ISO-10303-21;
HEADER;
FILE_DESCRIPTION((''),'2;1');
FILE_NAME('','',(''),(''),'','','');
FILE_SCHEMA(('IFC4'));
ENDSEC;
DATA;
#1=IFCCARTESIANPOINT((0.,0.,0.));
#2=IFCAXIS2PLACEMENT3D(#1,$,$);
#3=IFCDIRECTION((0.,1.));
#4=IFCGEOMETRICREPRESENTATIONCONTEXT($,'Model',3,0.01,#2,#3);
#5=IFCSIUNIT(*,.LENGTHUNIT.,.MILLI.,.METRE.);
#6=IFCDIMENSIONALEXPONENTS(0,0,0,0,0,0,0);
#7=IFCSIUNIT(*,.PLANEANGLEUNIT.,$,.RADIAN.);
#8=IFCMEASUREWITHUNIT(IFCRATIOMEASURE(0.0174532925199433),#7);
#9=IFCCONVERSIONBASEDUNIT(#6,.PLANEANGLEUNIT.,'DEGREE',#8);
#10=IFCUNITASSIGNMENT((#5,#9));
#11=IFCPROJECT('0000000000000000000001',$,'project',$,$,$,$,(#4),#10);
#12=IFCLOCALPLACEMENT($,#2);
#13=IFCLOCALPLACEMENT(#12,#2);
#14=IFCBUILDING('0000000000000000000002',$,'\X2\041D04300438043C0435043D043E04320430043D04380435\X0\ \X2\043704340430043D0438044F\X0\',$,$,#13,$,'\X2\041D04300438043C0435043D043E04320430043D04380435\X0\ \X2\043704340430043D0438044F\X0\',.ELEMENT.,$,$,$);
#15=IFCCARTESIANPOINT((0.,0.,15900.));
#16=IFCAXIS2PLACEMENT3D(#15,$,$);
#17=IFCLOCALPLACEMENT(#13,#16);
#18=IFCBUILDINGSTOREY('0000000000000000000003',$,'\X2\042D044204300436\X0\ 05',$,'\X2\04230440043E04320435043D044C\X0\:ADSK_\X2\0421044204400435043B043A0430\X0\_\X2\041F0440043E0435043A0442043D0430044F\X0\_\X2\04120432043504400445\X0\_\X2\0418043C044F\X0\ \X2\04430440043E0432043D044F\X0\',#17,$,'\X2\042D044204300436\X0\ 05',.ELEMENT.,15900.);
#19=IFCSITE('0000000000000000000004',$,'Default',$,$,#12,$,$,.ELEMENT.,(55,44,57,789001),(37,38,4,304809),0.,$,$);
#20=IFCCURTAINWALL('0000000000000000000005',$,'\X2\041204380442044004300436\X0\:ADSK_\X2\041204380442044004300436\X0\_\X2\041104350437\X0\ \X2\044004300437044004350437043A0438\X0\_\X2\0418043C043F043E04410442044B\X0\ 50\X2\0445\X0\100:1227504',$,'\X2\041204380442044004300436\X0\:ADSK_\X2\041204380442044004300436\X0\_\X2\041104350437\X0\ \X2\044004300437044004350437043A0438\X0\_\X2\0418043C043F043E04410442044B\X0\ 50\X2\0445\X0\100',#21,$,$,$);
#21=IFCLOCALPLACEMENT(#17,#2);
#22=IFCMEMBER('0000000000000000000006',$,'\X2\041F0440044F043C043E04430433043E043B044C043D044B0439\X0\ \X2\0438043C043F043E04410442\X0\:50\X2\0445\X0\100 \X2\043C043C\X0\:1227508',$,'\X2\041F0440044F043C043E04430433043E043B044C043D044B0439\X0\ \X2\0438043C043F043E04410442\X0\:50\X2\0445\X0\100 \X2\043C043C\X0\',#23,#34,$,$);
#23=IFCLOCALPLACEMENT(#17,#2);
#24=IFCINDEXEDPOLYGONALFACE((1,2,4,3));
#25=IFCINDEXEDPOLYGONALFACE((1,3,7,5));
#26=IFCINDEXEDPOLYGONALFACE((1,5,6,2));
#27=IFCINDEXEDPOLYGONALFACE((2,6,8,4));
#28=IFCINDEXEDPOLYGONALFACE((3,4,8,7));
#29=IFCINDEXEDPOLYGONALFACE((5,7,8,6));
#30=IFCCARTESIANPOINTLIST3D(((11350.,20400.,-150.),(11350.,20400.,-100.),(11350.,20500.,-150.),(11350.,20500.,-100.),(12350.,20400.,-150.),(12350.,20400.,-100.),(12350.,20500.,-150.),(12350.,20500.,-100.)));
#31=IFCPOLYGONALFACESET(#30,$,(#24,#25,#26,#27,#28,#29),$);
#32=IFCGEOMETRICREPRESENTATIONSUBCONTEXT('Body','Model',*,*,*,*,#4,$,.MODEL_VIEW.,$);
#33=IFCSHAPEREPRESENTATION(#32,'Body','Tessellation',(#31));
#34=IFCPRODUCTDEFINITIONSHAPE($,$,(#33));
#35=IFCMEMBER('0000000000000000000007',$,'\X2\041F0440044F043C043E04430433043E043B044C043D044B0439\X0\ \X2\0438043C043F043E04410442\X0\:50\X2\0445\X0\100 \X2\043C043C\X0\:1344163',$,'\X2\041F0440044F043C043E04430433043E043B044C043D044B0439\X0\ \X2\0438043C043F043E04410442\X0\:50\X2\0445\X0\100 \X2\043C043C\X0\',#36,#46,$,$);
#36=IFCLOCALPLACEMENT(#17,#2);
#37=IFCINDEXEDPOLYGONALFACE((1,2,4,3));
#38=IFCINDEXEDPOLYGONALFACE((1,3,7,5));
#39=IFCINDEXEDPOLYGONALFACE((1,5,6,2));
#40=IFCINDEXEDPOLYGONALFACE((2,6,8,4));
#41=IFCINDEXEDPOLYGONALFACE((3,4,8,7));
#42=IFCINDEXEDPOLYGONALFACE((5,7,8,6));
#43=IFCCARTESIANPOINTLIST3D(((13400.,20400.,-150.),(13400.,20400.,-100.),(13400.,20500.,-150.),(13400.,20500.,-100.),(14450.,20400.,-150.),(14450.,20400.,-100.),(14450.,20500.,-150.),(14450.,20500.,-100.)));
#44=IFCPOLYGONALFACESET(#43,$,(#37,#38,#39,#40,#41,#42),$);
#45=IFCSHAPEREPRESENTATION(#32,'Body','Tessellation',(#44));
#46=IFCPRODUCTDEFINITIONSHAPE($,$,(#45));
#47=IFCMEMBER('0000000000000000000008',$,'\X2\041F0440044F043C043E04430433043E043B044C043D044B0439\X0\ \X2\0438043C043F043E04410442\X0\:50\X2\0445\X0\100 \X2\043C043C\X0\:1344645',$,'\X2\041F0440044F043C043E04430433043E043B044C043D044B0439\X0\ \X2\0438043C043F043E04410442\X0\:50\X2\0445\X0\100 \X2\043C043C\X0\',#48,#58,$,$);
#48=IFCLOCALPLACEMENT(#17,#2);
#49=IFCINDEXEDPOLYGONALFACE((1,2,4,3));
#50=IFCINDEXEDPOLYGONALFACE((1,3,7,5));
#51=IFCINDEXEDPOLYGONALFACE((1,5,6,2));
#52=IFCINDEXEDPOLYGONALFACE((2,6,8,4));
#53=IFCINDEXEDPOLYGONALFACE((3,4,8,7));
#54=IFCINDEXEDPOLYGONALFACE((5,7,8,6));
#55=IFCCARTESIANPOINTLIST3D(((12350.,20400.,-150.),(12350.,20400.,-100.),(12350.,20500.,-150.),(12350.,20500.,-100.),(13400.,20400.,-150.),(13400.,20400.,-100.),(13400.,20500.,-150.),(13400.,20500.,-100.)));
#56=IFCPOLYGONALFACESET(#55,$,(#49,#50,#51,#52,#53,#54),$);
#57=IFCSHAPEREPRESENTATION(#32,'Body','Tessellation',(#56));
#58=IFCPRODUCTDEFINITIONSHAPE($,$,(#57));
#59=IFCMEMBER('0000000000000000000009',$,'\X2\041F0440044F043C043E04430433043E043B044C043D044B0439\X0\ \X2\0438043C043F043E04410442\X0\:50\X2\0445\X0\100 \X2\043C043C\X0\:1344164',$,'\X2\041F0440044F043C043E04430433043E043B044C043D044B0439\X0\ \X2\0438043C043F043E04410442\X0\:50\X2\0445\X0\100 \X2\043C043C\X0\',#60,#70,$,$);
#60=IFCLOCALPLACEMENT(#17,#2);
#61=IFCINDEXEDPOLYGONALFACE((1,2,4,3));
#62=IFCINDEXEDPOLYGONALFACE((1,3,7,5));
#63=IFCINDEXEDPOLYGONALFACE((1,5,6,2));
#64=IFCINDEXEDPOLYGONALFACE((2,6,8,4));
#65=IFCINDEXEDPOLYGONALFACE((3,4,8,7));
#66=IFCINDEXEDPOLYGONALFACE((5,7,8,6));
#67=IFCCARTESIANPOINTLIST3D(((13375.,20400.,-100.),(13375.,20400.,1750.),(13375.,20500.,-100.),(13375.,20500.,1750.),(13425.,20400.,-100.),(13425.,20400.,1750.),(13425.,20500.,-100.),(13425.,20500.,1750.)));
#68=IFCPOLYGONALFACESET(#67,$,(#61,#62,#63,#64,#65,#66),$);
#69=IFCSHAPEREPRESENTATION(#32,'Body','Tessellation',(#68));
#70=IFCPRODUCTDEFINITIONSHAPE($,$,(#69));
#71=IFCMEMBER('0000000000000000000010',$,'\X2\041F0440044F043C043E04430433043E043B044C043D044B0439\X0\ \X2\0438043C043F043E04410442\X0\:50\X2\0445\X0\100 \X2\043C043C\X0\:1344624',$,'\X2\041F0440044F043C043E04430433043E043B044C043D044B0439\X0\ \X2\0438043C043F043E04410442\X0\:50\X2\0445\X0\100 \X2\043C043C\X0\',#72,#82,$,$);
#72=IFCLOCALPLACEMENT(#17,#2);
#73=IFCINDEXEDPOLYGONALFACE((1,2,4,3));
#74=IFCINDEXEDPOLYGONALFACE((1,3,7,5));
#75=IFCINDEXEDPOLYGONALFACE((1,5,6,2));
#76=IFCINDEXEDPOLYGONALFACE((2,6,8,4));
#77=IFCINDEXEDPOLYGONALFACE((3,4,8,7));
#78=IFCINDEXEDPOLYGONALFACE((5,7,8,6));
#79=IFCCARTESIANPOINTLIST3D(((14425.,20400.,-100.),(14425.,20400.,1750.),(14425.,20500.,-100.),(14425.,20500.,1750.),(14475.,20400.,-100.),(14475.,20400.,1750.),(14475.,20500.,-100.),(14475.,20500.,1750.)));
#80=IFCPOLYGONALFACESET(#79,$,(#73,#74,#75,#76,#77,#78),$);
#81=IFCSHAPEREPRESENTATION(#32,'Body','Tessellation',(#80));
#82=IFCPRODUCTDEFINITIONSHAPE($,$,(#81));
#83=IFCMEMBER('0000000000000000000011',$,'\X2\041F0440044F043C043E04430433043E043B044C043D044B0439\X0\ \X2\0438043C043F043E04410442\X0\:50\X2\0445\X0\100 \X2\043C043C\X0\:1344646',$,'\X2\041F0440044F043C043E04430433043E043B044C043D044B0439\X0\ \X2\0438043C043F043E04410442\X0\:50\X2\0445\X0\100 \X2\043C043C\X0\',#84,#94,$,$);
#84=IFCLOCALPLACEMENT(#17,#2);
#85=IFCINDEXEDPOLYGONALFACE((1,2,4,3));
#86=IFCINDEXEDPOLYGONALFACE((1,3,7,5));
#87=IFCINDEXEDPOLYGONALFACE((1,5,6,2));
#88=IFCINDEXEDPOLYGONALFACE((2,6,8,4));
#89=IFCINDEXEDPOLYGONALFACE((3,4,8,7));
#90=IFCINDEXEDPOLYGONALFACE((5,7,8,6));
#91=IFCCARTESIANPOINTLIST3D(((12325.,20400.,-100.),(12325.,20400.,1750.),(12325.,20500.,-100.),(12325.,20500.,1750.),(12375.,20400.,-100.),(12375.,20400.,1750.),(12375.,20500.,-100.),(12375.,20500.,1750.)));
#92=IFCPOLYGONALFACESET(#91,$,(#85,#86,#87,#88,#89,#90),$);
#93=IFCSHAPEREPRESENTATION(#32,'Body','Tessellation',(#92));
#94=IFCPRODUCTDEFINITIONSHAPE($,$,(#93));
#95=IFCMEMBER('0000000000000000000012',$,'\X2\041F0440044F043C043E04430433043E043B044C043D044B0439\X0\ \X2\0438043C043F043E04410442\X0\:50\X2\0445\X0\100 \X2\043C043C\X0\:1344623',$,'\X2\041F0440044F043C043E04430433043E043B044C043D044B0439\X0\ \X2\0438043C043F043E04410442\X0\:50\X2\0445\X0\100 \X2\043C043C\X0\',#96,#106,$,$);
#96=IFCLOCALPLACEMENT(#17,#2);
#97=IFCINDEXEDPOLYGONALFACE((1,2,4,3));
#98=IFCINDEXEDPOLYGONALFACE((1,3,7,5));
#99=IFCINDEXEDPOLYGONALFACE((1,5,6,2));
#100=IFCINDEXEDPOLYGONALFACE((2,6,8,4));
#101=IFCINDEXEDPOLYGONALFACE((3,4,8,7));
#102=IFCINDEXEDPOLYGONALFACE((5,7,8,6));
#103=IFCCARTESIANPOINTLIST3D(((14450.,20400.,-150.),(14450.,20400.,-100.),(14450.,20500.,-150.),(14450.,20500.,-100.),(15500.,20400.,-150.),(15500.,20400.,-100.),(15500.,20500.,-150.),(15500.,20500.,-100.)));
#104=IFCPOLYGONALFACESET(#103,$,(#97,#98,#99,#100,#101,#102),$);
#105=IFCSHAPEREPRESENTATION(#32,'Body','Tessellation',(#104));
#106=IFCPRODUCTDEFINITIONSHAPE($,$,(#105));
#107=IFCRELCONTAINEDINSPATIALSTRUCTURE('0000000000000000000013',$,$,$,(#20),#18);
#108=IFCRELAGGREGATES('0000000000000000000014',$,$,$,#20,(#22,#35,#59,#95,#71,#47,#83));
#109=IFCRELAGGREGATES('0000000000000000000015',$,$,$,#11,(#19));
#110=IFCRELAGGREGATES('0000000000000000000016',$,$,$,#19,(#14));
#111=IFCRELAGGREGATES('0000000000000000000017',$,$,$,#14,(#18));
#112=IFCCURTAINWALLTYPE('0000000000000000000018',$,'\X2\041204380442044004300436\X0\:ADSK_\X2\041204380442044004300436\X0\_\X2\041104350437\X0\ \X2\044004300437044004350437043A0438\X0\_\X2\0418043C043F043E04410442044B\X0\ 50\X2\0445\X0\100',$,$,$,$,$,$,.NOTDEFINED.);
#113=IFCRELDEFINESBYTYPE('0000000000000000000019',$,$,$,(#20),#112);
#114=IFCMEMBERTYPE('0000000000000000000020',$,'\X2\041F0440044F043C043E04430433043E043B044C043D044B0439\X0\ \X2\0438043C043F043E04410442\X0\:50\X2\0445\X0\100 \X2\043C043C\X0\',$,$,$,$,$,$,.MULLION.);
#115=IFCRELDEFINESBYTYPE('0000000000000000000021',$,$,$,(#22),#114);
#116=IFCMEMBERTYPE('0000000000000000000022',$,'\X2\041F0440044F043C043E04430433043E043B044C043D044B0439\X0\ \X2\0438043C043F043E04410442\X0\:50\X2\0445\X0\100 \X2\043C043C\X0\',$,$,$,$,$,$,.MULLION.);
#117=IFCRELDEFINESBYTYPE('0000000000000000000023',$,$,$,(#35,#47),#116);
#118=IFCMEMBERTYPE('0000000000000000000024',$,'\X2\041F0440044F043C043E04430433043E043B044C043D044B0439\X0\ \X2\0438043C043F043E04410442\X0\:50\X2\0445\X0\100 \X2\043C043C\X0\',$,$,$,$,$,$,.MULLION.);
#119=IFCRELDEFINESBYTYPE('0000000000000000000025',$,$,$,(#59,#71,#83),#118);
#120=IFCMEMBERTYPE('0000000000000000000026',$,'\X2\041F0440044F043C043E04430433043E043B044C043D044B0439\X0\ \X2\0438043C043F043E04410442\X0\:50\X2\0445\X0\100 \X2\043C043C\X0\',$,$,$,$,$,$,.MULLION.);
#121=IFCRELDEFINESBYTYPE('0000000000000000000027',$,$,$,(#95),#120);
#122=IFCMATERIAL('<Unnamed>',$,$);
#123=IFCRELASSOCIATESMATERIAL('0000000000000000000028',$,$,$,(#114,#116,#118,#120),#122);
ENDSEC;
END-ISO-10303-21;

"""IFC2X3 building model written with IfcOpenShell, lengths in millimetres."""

from ifc_helpers import new_model, entity, si_unit, converted_unit, direction, frame, origin, origin_2d_with_axis, place, context, subcontext, project, spatial, rectangle, extrude, source, transform, mapped, material, type_object, type_shapes, element, aggregate, save


model = new_model("IFC2X3")

# Units and contexts
model_context = context("Model", 3, precision=0.01, world=origin(), true_north=direction((0.0, 1.0)))
body_context = subcontext(model_context, "Body", "Model", "MODEL_VIEW")
ifc_project = project(units=[si_unit("LENGTHUNIT", "METRE", prefix="MILLI"), converted_unit("PLANEANGLEUNIT", "DEGREE", entity("IfcRatioMeasure", 0.0174532925199433), si_unit("PLANEANGLEUNIT", "RADIAN"), dimensions=[0, 0, 0, 0, 0, 0, 0])], contexts=[model_context])

# Site, building, storey
site_placement = place(None, origin())
site = spatial("IfcSite", under=ifc_project, at=site_placement, Name="Default", CompositionType="ELEMENT", RefLatitude=(55, 44, 57, 789001), RefLongitude=(37, 38, 4, 304809), RefElevation=0.0)
building_placement = place(site_placement, origin())
building = spatial("IfcBuilding", under=site, at=building_placement, Name="Наименование здания", LongName="Наименование здания", CompositionType="ELEMENT")
storey_placement = place(building_placement, frame((0.0, 0.0, 15900.0)))
storey = spatial("IfcBuildingStorey", under=building, at=storey_placement, Name="Этаж 05", ObjectType="Уровень:ADSK_Стрелка_Проектная_Вверх_Имя уровня", LongName="Этаж 05", CompositionType="ELEMENT", Elevation=15900.0)

# Curtain wall, members
curtain_wall_type = type_object("IfcCurtainWallType", Name="Витраж:ADSK_Витраж_Без разрезки_Импосты 50х100", PredefinedType="NOTDEFINED")
curtain_wall_placement = place(storey_placement, frame((0.0, 0.0, -15900.0)))
curtain_wall = element("IfcCurtainWall", 1, at=curtain_wall_placement, inside=storey, type_object=curtain_wall_type, Name="Витраж:ADSK_Витраж_Без разрезки_Импосты 50х100:1227504", ObjectType="Витраж:ADSK_Витраж_Без разрезки_Импосты 50х100")
ifc_material_1 = material(Name="<Unnamed>")
member_type_1 = type_object("IfcMemberType", Name="Прямоугольный импост:50х100 мм", PredefinedType="MULLION", material=ifc_material_1)
shared_shape_1 = source(origin(), body_context, "Body", "SweptSolid", [
    extrude(rectangle(XDim=100.0, YDim=50.0, at=origin_2d_with_axis()), frame((-25.0, 0.0, -1000.0), z_axis=(0.0, 0.0, 1.0), x_axis=(0.0, -1.0, 0.0)), (0.0, 0.0, 1.0), 1000.0),
])
type_shapes(member_type_1, [shared_shape_1])
member_1_placement = place(storey_placement, frame((11350.0, 20450.0, -150.0), z_axis=(-1.0, 0.0, 0.0), x_axis=(0.0, 0.0, -1.0)))
member_1 = element("IfcMember", 2, at=member_1_placement, type_object=member_type_1, Name="Прямоугольный импост:50х100 мм:1227508", ObjectType="Прямоугольный импост:50х100 мм", context=body_context, shape_type="MappedRepresentation", body=[
    mapped(shared_shape_1, transform((0.0, 0.0, 0.0), scale=1.0)),
])
member_type_2 = type_object("IfcMemberType", Name="Прямоугольный импост:50х100 мм", PredefinedType="MULLION", material=ifc_material_1)
shared_shape_2 = source(origin(), body_context, "Body", "SweptSolid", [
    extrude(rectangle(XDim=100.0, YDim=50.0, at=origin_2d_with_axis()), frame((-25.0, 0.0, -1050.0), z_axis=(0.0, 0.0, 1.0), x_axis=(0.0, -1.0, 0.0)), (0.0, 0.0, 1.0), 1050.0),
])
type_shapes(member_type_2, [shared_shape_2])
member_2_placement = place(storey_placement, frame((13400.0, 20450.0, -150.0), z_axis=(-1.0, 0.0, 0.0), x_axis=(0.0, 0.0, -1.0)))
member_2 = element("IfcMember", 3, at=member_2_placement, type_object=member_type_2, Name="Прямоугольный импост:50х100 мм:1344163", ObjectType="Прямоугольный импост:50х100 мм", context=body_context, shape_type="MappedRepresentation", body=[
    mapped(shared_shape_2, transform((0.0, 0.0, 0.0), scale=1.0)),
])
member_3_placement = place(storey_placement, frame((12350.0, 20450.0, -150.0), z_axis=(-1.0, 0.0, 0.0), x_axis=(0.0, 0.0, -1.0)))
member_3 = element("IfcMember", 4, at=member_3_placement, type_object=member_type_2, Name="Прямоугольный импост:50х100 мм:1344645", ObjectType="Прямоугольный импост:50х100 мм", context=body_context, shape_type="MappedRepresentation", body=[
    mapped(shared_shape_2, transform((0.0, 0.0, 0.0), scale=1.0)),
])
member_type_3 = type_object("IfcMemberType", Name="Прямоугольный импост:50х100 мм", PredefinedType="MULLION", material=ifc_material_1)
shared_shape_3 = source(origin(), body_context, "Body", "SweptSolid", [
    extrude(rectangle(XDim=100.0, YDim=50.0, at=origin_2d_with_axis()), frame((0.0, 0.0, -1850.0), z_axis=(0.0, 0.0, 1.0), x_axis=(0.0, -1.0, 0.0)), (0.0, 0.0, 1.0), 1850.0),
])
type_shapes(member_type_3, [shared_shape_3])
member_4_placement = place(storey_placement, frame((13400.0, 20450.0, -100.0), z_axis=(0.0, 0.0, -1.0), x_axis=(1.0, 0.0, 0.0)))
member_4 = element("IfcMember", 5, at=member_4_placement, type_object=member_type_3, Name="Прямоугольный импост:50х100 мм:1344164", ObjectType="Прямоугольный импост:50х100 мм", context=body_context, shape_type="MappedRepresentation", body=[
    mapped(shared_shape_3, transform((0.0, 0.0, 0.0), scale=1.0)),
])
member_5_placement = place(storey_placement, frame((14450.0, 20450.0, -100.0), z_axis=(0.0, 0.0, -1.0), x_axis=(1.0, 0.0, 0.0)))
member_5 = element("IfcMember", 6, at=member_5_placement, type_object=member_type_3, Name="Прямоугольный импост:50х100 мм:1344624", ObjectType="Прямоугольный импост:50х100 мм", context=body_context, shape_type="MappedRepresentation", body=[
    mapped(shared_shape_3, transform((0.0, 0.0, 0.0), scale=1.0)),
])
member_6_placement = place(storey_placement, frame((12350.0, 20450.0, -100.0), z_axis=(0.0, 0.0, -1.0), x_axis=(1.0, 0.0, 0.0)))
member_6 = element("IfcMember", 7, at=member_6_placement, type_object=member_type_3, Name="Прямоугольный импост:50х100 мм:1344646", ObjectType="Прямоугольный импост:50х100 мм", context=body_context, shape_type="MappedRepresentation", body=[
    mapped(shared_shape_3, transform((0.0, 0.0, 0.0), scale=1.0)),
])
member_type_4 = type_object("IfcMemberType", Name="Прямоугольный импост:50х100 мм", PredefinedType="MULLION", material=ifc_material_1)
shared_shape_4 = source(origin(), body_context, "Body", "SweptSolid", [
    extrude(rectangle(XDim=100.0, YDim=50.0, at=origin_2d_with_axis()), frame((-25.0, 0.0, -1050.0), z_axis=(0.0, 0.0, 1.0), x_axis=(0.0, -1.0, 0.0)), (0.0, 0.0, 1.0), 1050.0),
])
type_shapes(member_type_4, [shared_shape_4])
member_7_placement = place(storey_placement, frame((14450.0, 20450.0, -150.0), z_axis=(-1.0, 0.0, 0.0), x_axis=(0.0, 0.0, -1.0)))
member_7 = element("IfcMember", 8, at=member_7_placement, type_object=member_type_4, Name="Прямоугольный импост:50х100 мм:1344623", ObjectType="Прямоугольный импост:50х100 мм", context=body_context, shape_type="MappedRepresentation", body=[
    mapped(shared_shape_4, transform((0.0, 0.0, 0.0), scale=1.0)),
])
aggregate(curtain_wall, [member_1, member_2, member_4, member_7, member_5, member_3, member_6])

save(model, "model.ifc")
